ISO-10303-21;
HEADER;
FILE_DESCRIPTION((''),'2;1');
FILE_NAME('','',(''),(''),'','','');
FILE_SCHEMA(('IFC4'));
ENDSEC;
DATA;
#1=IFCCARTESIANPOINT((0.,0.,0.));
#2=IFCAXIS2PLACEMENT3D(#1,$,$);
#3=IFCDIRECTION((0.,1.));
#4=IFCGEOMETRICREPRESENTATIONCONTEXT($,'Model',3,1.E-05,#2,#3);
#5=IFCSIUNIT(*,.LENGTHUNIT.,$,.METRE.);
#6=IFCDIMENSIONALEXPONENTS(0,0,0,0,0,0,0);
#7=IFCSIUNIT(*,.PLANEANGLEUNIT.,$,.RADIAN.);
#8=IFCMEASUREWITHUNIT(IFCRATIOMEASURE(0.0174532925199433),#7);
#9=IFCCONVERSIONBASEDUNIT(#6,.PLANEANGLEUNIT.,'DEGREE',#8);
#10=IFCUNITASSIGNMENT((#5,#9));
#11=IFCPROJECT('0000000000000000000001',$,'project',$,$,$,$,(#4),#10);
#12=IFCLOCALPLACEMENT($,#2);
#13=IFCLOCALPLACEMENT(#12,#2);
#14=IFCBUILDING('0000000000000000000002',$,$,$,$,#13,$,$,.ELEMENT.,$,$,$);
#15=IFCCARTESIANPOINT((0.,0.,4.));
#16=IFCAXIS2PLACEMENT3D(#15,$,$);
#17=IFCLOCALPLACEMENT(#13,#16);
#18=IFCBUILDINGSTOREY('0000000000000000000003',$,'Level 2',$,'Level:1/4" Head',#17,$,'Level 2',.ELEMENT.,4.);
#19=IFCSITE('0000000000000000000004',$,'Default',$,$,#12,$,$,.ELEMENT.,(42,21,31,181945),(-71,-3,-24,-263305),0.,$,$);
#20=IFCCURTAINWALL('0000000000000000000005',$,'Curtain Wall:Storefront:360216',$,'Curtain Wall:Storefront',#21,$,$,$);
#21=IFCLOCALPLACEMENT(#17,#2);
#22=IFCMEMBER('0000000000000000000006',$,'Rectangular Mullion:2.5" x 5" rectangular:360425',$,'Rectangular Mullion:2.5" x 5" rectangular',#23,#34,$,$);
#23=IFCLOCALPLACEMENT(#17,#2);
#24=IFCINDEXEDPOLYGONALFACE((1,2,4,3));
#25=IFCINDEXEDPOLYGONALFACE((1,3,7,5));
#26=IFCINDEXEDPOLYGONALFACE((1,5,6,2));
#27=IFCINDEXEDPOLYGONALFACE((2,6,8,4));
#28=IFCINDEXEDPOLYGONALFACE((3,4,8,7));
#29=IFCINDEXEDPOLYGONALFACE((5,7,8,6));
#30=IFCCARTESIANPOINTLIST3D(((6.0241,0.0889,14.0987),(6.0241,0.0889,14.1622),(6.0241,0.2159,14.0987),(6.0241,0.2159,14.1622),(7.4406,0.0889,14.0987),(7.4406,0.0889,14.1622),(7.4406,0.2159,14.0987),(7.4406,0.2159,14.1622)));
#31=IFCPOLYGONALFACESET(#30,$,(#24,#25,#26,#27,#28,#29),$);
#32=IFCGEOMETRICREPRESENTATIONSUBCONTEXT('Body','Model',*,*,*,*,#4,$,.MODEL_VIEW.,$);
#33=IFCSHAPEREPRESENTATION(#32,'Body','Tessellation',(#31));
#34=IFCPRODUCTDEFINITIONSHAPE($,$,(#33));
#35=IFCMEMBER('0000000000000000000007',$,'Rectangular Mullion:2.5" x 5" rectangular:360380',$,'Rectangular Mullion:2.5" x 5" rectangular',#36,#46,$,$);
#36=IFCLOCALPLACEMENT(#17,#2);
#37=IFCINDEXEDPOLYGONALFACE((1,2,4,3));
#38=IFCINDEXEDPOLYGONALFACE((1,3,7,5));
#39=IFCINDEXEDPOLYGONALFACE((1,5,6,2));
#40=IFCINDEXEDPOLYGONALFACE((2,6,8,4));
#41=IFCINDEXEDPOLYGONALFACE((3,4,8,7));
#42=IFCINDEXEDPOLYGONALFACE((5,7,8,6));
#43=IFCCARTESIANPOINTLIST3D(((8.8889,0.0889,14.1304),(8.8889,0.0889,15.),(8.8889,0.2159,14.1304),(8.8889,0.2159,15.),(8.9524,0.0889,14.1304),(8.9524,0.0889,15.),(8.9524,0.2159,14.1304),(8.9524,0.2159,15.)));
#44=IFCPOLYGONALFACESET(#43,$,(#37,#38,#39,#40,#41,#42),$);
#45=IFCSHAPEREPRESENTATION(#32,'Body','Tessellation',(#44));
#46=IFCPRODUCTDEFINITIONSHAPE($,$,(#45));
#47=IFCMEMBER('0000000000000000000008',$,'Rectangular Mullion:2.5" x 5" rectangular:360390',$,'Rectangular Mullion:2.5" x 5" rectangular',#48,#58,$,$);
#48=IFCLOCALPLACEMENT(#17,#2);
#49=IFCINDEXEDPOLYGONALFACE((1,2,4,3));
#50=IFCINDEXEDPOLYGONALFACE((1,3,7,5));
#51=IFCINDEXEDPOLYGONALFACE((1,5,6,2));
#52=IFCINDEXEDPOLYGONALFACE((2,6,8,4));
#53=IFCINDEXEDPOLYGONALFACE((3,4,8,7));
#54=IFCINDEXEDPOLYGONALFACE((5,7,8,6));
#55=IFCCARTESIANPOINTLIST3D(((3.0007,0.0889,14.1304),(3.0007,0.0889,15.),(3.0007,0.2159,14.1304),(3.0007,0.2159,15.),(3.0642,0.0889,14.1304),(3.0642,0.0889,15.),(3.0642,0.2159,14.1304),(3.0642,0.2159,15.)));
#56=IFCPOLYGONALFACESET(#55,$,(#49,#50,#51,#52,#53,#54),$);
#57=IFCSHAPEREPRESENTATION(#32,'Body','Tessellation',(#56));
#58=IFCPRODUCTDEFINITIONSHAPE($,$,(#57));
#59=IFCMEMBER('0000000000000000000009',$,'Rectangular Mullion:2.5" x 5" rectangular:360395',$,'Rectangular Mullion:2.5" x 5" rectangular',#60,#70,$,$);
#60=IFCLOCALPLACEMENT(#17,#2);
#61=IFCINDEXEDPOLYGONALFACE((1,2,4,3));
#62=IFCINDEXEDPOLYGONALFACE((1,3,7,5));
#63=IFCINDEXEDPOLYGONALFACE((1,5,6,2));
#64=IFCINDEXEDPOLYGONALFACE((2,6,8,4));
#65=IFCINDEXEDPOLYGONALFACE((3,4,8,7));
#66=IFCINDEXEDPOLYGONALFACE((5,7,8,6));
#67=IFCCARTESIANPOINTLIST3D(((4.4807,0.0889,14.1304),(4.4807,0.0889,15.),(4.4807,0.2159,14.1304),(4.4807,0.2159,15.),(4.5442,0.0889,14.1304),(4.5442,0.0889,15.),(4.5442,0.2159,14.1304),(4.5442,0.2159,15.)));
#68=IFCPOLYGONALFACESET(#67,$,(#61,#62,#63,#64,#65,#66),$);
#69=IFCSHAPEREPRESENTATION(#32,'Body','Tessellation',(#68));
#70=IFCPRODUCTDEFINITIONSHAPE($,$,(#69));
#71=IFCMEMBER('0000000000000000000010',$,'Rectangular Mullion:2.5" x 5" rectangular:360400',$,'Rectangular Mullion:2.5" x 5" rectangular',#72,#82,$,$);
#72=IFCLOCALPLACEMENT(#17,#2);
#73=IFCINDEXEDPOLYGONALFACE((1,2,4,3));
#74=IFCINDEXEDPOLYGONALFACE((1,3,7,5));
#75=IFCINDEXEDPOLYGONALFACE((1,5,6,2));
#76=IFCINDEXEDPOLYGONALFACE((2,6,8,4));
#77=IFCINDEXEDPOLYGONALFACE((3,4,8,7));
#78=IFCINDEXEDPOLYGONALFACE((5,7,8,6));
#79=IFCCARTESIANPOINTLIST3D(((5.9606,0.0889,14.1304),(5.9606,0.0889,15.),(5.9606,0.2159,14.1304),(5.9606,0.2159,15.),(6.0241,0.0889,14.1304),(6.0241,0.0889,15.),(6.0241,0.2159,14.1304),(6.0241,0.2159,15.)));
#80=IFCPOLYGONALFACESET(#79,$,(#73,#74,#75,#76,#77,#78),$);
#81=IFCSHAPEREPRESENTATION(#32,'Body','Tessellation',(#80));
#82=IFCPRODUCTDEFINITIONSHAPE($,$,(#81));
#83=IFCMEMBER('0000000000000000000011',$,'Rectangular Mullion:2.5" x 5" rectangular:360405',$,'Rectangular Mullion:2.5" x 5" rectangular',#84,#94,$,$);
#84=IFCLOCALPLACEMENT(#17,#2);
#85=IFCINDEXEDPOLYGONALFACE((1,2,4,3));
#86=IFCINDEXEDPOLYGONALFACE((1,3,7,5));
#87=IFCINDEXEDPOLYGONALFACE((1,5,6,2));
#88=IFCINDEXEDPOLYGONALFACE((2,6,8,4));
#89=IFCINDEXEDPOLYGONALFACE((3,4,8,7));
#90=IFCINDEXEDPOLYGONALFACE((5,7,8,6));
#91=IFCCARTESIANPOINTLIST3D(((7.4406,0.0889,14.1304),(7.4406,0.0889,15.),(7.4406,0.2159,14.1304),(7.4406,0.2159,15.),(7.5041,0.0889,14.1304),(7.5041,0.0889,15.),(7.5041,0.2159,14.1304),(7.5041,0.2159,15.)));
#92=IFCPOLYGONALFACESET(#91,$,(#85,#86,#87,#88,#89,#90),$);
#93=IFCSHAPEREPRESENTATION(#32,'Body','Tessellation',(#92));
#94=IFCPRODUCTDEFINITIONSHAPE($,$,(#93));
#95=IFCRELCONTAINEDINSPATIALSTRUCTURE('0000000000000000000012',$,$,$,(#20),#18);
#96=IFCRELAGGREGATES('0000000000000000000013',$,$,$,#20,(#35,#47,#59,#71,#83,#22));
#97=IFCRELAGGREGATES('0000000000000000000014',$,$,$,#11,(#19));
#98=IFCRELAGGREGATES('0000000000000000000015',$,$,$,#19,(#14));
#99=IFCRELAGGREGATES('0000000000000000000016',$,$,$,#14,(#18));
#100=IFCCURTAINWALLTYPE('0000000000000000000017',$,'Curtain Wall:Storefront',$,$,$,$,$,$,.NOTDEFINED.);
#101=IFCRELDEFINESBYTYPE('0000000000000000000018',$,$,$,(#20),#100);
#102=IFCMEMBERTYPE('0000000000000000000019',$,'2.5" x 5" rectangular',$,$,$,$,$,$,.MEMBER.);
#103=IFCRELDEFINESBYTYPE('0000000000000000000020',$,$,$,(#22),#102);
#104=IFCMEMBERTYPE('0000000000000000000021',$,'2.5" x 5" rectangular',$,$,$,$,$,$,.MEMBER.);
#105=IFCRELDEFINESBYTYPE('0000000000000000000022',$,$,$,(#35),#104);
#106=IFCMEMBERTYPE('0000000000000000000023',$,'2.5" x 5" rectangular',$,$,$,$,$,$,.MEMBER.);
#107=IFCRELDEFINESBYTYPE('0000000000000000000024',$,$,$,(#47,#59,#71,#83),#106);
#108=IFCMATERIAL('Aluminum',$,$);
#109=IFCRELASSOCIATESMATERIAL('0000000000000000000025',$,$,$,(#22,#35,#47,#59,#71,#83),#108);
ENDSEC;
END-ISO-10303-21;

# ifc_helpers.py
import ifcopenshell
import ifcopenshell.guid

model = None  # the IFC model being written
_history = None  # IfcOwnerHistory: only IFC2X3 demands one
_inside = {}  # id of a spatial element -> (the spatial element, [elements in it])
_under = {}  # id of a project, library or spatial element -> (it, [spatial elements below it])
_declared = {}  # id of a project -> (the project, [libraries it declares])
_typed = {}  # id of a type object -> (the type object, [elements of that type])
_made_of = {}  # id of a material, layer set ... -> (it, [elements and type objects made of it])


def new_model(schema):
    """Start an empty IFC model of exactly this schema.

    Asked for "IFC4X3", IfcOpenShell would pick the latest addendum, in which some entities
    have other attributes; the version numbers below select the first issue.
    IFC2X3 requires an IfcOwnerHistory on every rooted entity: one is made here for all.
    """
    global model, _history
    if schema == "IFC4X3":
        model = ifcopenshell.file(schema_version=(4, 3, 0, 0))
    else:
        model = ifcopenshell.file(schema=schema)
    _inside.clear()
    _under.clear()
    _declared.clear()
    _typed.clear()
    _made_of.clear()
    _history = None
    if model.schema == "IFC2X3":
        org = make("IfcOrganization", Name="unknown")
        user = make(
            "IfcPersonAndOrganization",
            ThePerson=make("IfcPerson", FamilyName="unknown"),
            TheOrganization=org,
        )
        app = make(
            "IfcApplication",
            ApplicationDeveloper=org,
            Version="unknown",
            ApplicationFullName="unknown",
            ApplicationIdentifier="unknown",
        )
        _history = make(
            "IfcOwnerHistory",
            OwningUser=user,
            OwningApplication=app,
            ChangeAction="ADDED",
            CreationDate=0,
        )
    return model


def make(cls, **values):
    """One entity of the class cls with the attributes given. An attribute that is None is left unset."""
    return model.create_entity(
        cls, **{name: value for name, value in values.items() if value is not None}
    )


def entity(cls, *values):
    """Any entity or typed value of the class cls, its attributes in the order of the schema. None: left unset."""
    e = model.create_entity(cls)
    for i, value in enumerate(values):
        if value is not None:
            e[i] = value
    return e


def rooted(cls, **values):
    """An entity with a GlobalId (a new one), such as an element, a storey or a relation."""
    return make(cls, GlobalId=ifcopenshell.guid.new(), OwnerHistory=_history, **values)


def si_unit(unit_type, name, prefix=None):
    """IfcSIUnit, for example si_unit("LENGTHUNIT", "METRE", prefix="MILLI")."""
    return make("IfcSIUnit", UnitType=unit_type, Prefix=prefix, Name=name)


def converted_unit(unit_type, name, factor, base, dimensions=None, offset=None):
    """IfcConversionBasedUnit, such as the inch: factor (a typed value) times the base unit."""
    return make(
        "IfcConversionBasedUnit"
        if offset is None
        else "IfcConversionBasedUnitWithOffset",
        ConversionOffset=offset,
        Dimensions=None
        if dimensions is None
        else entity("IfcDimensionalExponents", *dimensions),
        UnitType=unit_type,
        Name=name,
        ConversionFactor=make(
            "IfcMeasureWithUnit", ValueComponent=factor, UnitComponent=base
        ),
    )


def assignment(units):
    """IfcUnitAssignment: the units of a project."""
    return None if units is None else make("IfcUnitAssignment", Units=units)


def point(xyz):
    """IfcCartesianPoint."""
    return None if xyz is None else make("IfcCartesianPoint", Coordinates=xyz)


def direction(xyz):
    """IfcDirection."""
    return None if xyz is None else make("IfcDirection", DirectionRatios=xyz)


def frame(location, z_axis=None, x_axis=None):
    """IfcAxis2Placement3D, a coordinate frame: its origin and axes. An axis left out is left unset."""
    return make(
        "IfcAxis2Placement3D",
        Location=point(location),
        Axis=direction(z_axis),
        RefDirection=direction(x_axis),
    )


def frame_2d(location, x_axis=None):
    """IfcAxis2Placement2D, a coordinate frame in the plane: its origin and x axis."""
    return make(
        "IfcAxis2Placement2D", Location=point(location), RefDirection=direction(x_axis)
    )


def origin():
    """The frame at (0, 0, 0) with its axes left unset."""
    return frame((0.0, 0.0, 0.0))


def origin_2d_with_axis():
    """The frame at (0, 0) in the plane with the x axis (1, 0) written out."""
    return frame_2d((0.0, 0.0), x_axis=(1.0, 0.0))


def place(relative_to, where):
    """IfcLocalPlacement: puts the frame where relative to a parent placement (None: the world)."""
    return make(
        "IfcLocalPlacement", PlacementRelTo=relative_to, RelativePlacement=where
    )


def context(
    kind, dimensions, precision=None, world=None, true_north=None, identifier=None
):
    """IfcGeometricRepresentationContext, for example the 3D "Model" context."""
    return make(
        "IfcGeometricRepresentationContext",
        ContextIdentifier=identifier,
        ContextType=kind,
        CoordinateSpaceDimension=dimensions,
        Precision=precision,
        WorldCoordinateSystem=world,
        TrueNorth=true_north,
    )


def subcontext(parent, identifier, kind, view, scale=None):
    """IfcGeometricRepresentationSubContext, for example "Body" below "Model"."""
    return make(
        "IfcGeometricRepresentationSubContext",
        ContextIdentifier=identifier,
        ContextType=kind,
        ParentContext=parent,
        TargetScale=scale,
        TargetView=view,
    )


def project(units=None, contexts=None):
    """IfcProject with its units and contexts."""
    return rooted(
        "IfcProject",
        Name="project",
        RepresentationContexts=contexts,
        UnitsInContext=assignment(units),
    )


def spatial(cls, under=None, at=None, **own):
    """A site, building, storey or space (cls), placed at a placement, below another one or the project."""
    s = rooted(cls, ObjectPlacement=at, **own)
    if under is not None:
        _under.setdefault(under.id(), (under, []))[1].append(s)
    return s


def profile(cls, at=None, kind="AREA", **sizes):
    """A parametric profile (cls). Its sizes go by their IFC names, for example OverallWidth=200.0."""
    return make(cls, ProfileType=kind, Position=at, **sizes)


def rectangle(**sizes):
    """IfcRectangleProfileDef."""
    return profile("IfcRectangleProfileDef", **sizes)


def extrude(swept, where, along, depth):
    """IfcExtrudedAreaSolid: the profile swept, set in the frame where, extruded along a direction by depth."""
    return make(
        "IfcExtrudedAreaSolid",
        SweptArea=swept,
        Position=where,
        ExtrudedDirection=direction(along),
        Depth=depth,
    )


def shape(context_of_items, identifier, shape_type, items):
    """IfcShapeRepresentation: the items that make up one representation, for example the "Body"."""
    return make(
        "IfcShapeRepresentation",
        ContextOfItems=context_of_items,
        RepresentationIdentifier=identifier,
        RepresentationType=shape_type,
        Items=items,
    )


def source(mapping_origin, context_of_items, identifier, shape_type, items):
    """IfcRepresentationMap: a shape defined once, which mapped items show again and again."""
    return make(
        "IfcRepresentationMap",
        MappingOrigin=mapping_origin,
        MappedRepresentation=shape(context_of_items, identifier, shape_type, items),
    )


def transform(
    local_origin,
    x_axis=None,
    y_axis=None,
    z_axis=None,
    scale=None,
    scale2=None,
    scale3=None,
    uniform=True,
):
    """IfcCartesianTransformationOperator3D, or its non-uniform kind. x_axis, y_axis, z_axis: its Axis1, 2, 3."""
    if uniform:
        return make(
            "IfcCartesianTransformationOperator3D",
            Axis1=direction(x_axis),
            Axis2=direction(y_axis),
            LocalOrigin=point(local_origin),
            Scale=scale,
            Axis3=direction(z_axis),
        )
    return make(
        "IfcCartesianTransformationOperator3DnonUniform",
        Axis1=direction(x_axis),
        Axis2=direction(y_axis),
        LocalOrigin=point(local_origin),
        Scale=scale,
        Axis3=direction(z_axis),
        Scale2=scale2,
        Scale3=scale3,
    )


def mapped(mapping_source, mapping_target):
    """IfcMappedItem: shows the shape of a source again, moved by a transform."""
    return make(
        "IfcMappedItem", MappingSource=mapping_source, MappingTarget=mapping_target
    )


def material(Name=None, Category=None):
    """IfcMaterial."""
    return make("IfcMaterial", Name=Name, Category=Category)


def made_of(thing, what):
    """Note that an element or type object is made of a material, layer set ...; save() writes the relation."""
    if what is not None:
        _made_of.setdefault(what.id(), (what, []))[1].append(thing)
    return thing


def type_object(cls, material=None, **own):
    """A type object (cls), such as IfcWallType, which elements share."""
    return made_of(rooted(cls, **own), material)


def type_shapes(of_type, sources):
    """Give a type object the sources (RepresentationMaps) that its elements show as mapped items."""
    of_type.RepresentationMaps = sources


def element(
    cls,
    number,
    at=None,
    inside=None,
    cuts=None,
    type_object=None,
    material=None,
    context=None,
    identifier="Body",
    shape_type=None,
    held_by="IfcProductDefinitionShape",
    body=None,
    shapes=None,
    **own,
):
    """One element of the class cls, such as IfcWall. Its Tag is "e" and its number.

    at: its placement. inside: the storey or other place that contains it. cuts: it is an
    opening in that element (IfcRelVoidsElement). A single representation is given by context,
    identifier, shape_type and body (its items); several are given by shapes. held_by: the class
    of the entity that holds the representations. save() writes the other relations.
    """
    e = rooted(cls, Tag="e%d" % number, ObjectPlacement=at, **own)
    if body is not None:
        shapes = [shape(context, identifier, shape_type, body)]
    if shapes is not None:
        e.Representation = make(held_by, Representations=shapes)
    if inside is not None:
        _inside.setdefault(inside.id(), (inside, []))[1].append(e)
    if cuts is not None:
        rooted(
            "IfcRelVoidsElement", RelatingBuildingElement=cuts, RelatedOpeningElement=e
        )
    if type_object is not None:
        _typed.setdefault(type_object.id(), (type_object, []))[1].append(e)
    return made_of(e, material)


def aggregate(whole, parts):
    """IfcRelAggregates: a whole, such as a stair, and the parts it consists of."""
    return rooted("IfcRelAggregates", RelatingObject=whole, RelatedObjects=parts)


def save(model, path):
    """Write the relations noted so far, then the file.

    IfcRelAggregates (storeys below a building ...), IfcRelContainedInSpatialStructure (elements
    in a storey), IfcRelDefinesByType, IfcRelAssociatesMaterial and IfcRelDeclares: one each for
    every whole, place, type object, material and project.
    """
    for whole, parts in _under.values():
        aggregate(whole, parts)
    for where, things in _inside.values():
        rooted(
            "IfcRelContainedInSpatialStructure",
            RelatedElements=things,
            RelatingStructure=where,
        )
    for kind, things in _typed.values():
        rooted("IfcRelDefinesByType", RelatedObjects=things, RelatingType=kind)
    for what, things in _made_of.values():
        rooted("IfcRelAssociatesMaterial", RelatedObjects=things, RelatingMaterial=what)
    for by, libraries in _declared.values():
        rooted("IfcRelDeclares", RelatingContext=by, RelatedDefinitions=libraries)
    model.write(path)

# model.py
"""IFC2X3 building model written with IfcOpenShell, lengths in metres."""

from ifc_helpers import new_model, entity, si_unit, converted_unit, direction, frame, origin, origin_2d_with_axis, place, context, subcontext, project, spatial, rectangle, extrude, source, transform, mapped, material, type_object, type_shapes, element, aggregate, save


model = new_model("IFC2X3")

# Units and contexts
model_context = context("Model", 3, precision=1e-05, world=origin(), true_north=direction((0.0, 1.0)))
body_context = subcontext(model_context, "Body", "Model", "MODEL_VIEW")
ifc_project = project(units=[si_unit("LENGTHUNIT", "METRE"), converted_unit("PLANEANGLEUNIT", "DEGREE", entity("IfcRatioMeasure", 0.0174532925199433), si_unit("PLANEANGLEUNIT", "RADIAN"), dimensions=[0, 0, 0, 0, 0, 0, 0])], contexts=[model_context])

# Site, building, storey
site_placement = place(None, origin())
site = spatial("IfcSite", under=ifc_project, at=site_placement, Name="Default", CompositionType="ELEMENT", RefLatitude=(42, 21, 31, 181945), RefLongitude=(-71, -3, -24, -263305), RefElevation=0.0)
building_placement = place(site_placement, origin())
building = spatial("IfcBuilding", under=site, at=building_placement, CompositionType="ELEMENT")
storey_placement = place(building_placement, frame((0.0, 0.0, 4.0)))
storey = spatial("IfcBuildingStorey", under=building, at=storey_placement, Name="Level 2", ObjectType="Level:1/4\" Head", LongName="Level 2", CompositionType="ELEMENT", Elevation=4.0)

# Curtain wall, members
curtain_wall_type = type_object("IfcCurtainWallType", Name="Curtain Wall:Storefront", PredefinedType="NOTDEFINED")
curtain_wall_placement = place(storey_placement, frame((0.0, 0.0, -4.0)))
curtain_wall = element("IfcCurtainWall", 1, at=curtain_wall_placement, inside=storey, type_object=curtain_wall_type, Name="Curtain Wall:Storefront:360216", ObjectType="Curtain Wall:Storefront")
ifc_material_1 = material(Name="Aluminum")
member_type_1 = type_object("IfcMemberType", Name="2.5\" x 5\" rectangular", PredefinedType="MEMBER")
shared_shape_1 = source(origin(), body_context, "Body", "SweptSolid", [
    extrude(rectangle(XDim=0.127, YDim=0.0635, at=origin_2d_with_axis()), frame((0.0, 0.0, -1.4165), z_axis=(0.0, 0.0, 1.0), x_axis=(0.0, -1.0, 0.0)), (0.0, 0.0, 1.0), 1.4165),
])
type_shapes(member_type_1, [shared_shape_1])
member_1_placement = place(storey_placement, frame((7.4406, 0.1524, 14.1304), z_axis=(1.0, 0.0, 0.0), x_axis=(0.0, 0.0, 1.0)))
member_1 = element("IfcMember", 2, at=member_1_placement, type_object=member_type_1, material=ifc_material_1, Name="Rectangular Mullion:2.5\" x 5\" rectangular:360425", ObjectType="Rectangular Mullion:2.5\" x 5\" rectangular", context=body_context, shape_type="MappedRepresentation", body=[
    mapped(shared_shape_1, transform((0.0, 0.0, 0.0), scale=1.0)),
])
member_type_2 = type_object("IfcMemberType", Name="2.5\" x 5\" rectangular", PredefinedType="MEMBER")
shared_shape_2 = source(origin(), body_context, "Body", "SweptSolid", [
    extrude(rectangle(XDim=0.127, YDim=0.0635, at=origin_2d_with_axis()), frame((-0.0318, 0.0, -0.8696), z_axis=(0.0, 0.0, 1.0), x_axis=(0.0, -1.0, 0.0)), (0.0, 0.0, 1.0), 0.8696),
])
type_shapes(member_type_2, [shared_shape_2])
member_2_placement = place(storey_placement, frame((8.9524, 0.1524, 14.1304), z_axis=(0.0, 0.0, -1.0), x_axis=(1.0, 0.0, 0.0)))
member_2 = element("IfcMember", 3, at=member_2_placement, type_object=member_type_2, material=ifc_material_1, Name="Rectangular Mullion:2.5\" x 5\" rectangular:360380", ObjectType="Rectangular Mullion:2.5\" x 5\" rectangular", context=body_context, shape_type="MappedRepresentation", body=[
    mapped(shared_shape_2, transform((0.0, 0.0, 0.0), scale=1.0)),
])
member_type_3 = type_object("IfcMemberType", Name="2.5\" x 5\" rectangular", PredefinedType="MEMBER")
shared_shape_3 = source(origin(), body_context, "Body", "SweptSolid", [
    extrude(rectangle(XDim=0.127, YDim=0.0635, at=origin_2d_with_axis()), frame((0.0, 0.0, -0.8696), z_axis=(0.0, 0.0, 1.0), x_axis=(0.0, -1.0, 0.0)), (0.0, 0.0, 1.0), 0.8696),
])
type_shapes(member_type_3, [shared_shape_3])
member_3_placement = place(storey_placement, frame((3.0324, 0.1524, 14.1304), z_axis=(0.0, 0.0, -1.0), x_axis=(1.0, 0.0, 0.0)))
member_3 = element("IfcMember", 4, at=member_3_placement, type_object=member_type_3, material=ifc_material_1, Name="Rectangular Mullion:2.5\" x 5\" rectangular:360390", ObjectType="Rectangular Mullion:2.5\" x 5\" rectangular", context=body_context, shape_type="MappedRepresentation", body=[
    mapped(shared_shape_3, transform((0.0, 0.0, 0.0), scale=1.0)),
])
member_4_placement = place(storey_placement, frame((4.5124, 0.1524, 14.1304), z_axis=(0.0, 0.0, -1.0), x_axis=(1.0, 0.0, 0.0)))
member_4 = element("IfcMember", 5, at=member_4_placement, type_object=member_type_3, material=ifc_material_1, Name="Rectangular Mullion:2.5\" x 5\" rectangular:360395", ObjectType="Rectangular Mullion:2.5\" x 5\" rectangular", context=body_context, shape_type="MappedRepresentation", body=[
    mapped(shared_shape_3, transform((0.0, 0.0, 0.0), scale=1.0)),
])
member_5_placement = place(storey_placement, frame((5.9924, 0.1524, 14.1304), z_axis=(0.0, 0.0, -1.0), x_axis=(1.0, 0.0, 0.0)))
member_5 = element("IfcMember", 6, at=member_5_placement, type_object=member_type_3, material=ifc_material_1, Name="Rectangular Mullion:2.5\" x 5\" rectangular:360400", ObjectType="Rectangular Mullion:2.5\" x 5\" rectangular", context=body_context, shape_type="MappedRepresentation", body=[
    mapped(shared_shape_3, transform((0.0, 0.0, 0.0), scale=1.0)),
])
member_6_placement = place(storey_placement, frame((7.4724, 0.1524, 14.1304), z_axis=(0.0, 0.0, -1.0), x_axis=(1.0, 0.0, 0.0)))
member_6 = element("IfcMember", 7, at=member_6_placement, type_object=member_type_3, material=ifc_material_1, Name="Rectangular Mullion:2.5\" x 5\" rectangular:360405", ObjectType="Rectangular Mullion:2.5\" x 5\" rectangular", context=body_context, shape_type="MappedRepresentation", body=[
    mapped(shared_shape_3, transform((0.0, 0.0, 0.0), scale=1.0)),
])
aggregate(curtain_wall, [member_2, member_3, member_4, member_5, member_6, member_1])

save(model, "model.ifc")
